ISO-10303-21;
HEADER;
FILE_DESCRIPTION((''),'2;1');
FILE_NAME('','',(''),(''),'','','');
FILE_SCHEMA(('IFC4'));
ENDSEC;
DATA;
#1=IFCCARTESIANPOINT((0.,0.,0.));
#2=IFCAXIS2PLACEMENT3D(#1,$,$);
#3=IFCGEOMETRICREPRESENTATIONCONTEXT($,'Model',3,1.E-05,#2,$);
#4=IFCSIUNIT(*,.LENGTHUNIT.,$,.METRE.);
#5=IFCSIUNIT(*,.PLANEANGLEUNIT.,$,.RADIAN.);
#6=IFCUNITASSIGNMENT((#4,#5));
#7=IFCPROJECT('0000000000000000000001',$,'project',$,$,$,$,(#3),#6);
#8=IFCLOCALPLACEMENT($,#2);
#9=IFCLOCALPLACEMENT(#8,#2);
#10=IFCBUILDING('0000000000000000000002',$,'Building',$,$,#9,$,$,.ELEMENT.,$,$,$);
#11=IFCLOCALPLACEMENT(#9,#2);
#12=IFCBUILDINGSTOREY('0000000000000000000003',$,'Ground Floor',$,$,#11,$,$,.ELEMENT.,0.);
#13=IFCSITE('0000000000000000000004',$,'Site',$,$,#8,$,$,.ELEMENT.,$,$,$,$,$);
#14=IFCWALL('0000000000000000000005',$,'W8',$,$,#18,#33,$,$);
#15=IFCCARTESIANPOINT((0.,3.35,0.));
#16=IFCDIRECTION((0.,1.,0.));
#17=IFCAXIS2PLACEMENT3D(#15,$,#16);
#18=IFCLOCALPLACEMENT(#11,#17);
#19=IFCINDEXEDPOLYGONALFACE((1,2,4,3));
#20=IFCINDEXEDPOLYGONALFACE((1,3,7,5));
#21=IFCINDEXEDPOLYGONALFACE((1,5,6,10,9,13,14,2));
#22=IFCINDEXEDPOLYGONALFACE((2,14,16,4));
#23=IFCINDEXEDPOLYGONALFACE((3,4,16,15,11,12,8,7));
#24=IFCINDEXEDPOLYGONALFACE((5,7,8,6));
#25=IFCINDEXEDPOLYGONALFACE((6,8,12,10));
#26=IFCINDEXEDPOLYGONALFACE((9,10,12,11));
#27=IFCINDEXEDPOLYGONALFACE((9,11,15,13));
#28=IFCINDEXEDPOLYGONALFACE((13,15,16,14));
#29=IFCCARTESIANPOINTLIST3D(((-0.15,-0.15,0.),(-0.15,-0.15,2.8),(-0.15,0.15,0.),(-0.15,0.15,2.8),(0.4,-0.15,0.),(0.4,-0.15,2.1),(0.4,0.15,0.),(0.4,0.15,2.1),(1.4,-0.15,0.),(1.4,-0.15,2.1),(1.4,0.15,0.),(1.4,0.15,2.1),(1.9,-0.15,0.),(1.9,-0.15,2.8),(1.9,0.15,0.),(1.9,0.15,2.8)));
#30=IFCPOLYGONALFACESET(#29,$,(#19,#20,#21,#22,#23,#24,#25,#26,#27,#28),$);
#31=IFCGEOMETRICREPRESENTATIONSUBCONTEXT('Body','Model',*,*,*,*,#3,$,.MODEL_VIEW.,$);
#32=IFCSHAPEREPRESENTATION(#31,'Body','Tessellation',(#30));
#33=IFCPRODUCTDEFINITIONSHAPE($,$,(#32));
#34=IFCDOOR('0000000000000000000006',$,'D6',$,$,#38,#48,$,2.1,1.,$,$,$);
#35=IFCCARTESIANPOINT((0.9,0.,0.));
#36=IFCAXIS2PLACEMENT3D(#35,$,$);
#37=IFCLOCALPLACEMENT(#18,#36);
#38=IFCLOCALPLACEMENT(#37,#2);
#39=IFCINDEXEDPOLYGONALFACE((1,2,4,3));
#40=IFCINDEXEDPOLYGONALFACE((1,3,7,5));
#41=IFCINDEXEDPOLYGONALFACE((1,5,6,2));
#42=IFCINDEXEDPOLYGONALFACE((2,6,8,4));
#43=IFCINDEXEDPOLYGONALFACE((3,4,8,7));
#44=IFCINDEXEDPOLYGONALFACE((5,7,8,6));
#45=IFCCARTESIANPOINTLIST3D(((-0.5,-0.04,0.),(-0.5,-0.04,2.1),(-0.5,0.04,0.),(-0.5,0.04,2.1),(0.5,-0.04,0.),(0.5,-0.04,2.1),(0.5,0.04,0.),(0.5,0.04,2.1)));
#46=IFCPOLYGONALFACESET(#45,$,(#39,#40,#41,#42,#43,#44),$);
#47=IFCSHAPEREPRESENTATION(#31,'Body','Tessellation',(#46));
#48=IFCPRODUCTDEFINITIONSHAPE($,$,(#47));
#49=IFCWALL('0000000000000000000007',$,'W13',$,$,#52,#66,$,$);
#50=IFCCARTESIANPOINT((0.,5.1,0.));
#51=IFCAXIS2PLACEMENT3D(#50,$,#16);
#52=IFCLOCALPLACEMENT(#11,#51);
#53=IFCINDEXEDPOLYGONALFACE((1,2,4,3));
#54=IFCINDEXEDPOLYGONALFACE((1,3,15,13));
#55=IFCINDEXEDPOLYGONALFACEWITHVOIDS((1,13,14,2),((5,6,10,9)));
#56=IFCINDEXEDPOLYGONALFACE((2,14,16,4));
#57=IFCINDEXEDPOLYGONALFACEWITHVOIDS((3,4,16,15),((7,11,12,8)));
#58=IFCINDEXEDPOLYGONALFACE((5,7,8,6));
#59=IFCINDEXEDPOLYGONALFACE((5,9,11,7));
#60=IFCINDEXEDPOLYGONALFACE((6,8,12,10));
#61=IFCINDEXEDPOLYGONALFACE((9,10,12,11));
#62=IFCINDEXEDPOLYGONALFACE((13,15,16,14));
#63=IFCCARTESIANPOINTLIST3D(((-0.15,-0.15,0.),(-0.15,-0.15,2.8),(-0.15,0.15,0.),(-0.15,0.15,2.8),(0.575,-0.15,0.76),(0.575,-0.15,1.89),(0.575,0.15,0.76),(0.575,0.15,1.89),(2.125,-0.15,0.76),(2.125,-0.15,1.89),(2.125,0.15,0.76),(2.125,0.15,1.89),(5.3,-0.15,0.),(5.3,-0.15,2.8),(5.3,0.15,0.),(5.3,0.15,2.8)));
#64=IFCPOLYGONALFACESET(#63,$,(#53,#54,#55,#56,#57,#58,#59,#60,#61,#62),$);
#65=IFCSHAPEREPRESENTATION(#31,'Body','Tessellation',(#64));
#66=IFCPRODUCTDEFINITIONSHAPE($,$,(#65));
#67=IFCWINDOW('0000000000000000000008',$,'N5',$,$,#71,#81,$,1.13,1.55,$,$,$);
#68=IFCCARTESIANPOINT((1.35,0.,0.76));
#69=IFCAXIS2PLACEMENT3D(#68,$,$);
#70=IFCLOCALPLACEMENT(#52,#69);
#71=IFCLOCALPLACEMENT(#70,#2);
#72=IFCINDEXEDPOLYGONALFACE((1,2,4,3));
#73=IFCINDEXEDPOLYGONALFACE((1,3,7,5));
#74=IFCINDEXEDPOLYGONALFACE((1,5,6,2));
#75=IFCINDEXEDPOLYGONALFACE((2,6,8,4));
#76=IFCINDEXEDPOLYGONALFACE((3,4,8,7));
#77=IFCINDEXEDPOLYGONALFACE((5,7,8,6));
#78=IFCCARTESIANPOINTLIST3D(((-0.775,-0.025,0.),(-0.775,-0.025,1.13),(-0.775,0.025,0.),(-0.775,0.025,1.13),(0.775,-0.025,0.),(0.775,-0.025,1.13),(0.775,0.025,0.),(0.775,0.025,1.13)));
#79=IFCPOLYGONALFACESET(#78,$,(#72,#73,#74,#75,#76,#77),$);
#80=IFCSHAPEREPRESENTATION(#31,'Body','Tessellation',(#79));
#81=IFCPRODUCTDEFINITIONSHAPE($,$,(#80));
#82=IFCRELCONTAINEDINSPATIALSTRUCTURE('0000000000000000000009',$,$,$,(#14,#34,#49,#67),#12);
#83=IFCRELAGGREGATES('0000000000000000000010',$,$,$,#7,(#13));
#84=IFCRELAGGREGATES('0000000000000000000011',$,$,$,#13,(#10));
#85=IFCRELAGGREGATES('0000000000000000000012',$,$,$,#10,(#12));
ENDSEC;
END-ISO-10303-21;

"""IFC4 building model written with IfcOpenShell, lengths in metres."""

from ifc_helpers import new_model, si_unit, frame, frame_2d, origin, origin_2d, place, context, subcontext, project, spatial, rectangle, extrude, element, fill, save


model = new_model("IFC4")

# Units and contexts
model_context = context("Model", 3, precision=1e-05, world=origin())
body_context = subcontext(model_context, "Body", "Model", "MODEL_VIEW")
ifc_project = project(units=[si_unit("LENGTHUNIT", "METRE"), si_unit("PLANEANGLEUNIT", "RADIAN")], contexts=[model_context])

# Site, building, storey
site_placement = place(None, origin())
site = spatial("IfcSite", under=ifc_project, at=site_placement, Name="Site", CompositionType="ELEMENT")
building_placement = place(site_placement, origin())
building = spatial("IfcBuilding", under=site, at=building_placement, Name="Building", CompositionType="ELEMENT")
storey_placement = place(building_placement, origin())
storey = spatial("IfcBuildingStorey", under=building, at=storey_placement, Name="Ground Floor", CompositionType="ELEMENT", Elevation=0.0)

# Wall, opening, door
wall_1_placement = place(storey_placement, frame((0.0, 3.35, 0.0), x_axis=(0.0, 1.0, 0.0)))
wall_1 = element("IfcWall", 1, at=wall_1_placement, inside=storey, Name="W8", context=body_context, shape_type="SweptSolid", body=[
    extrude(rectangle(XDim=2.05, YDim=0.3, at=frame_2d((0.875, 0.0))), origin(), (0.0, 0.0, 1.0), 2.8),
])
opening_1_placement = place(wall_1_placement, frame((0.9, 0.0, 0.0)))
opening_1 = element("IfcOpeningElement", 2, at=opening_1_placement, cuts=wall_1, context=body_context, shape_type="SweptSolid", body=[
    extrude(rectangle(XDim=1.0, YDim=0.4, at=origin_2d()), origin(), (0.0, 0.0, 1.0), 2.1),
])
door_1_placement = place(opening_1_placement, origin())
door_1 = element("IfcDoor", 3, at=door_1_placement, inside=storey, Name="D6", OverallHeight=2.1, OverallWidth=1.0, context=body_context, shape_type="SweptSolid", body=[
    extrude(rectangle(XDim=1.0, YDim=0.08, at=origin_2d()), origin(), (0.0, 0.0, 1.0), 2.1),
])
fill(opening_1, door_1)

# Wall, opening, window
wall_2_placement = place(storey_placement, frame((0.0, 5.1, 0.0), x_axis=(0.0, 1.0, 0.0)))
wall_2 = element("IfcWall", 4, at=wall_2_placement, inside=storey, Name="W13", context=body_context, shape_type="SweptSolid", body=[
    extrude(rectangle(XDim=5.45, YDim=0.3, at=frame_2d((2.575, 0.0))), origin(), (0.0, 0.0, 1.0), 2.8),
])
opening_2_placement = place(wall_2_placement, frame((1.35, 0.0, 0.76)))
opening_2 = element("IfcOpeningElement", 5, at=opening_2_placement, cuts=wall_2, context=body_context, shape_type="SweptSolid", body=[
    extrude(rectangle(XDim=1.55, YDim=0.4, at=origin_2d()), origin(), (0.0, 0.0, 1.0), 1.13),
])
window_1_placement = place(opening_2_placement, origin())
window_1 = element("IfcWindow", 6, at=window_1_placement, inside=storey, Name="N5", OverallHeight=1.13, OverallWidth=1.55, context=body_context, shape_type="SweptSolid", body=[
    extrude(rectangle(XDim=1.55, YDim=0.05, at=origin_2d()), origin(), (0.0, 0.0, 1.0), 1.13),
])
fill(opening_2, window_1)

save(model, "model.ifc")
